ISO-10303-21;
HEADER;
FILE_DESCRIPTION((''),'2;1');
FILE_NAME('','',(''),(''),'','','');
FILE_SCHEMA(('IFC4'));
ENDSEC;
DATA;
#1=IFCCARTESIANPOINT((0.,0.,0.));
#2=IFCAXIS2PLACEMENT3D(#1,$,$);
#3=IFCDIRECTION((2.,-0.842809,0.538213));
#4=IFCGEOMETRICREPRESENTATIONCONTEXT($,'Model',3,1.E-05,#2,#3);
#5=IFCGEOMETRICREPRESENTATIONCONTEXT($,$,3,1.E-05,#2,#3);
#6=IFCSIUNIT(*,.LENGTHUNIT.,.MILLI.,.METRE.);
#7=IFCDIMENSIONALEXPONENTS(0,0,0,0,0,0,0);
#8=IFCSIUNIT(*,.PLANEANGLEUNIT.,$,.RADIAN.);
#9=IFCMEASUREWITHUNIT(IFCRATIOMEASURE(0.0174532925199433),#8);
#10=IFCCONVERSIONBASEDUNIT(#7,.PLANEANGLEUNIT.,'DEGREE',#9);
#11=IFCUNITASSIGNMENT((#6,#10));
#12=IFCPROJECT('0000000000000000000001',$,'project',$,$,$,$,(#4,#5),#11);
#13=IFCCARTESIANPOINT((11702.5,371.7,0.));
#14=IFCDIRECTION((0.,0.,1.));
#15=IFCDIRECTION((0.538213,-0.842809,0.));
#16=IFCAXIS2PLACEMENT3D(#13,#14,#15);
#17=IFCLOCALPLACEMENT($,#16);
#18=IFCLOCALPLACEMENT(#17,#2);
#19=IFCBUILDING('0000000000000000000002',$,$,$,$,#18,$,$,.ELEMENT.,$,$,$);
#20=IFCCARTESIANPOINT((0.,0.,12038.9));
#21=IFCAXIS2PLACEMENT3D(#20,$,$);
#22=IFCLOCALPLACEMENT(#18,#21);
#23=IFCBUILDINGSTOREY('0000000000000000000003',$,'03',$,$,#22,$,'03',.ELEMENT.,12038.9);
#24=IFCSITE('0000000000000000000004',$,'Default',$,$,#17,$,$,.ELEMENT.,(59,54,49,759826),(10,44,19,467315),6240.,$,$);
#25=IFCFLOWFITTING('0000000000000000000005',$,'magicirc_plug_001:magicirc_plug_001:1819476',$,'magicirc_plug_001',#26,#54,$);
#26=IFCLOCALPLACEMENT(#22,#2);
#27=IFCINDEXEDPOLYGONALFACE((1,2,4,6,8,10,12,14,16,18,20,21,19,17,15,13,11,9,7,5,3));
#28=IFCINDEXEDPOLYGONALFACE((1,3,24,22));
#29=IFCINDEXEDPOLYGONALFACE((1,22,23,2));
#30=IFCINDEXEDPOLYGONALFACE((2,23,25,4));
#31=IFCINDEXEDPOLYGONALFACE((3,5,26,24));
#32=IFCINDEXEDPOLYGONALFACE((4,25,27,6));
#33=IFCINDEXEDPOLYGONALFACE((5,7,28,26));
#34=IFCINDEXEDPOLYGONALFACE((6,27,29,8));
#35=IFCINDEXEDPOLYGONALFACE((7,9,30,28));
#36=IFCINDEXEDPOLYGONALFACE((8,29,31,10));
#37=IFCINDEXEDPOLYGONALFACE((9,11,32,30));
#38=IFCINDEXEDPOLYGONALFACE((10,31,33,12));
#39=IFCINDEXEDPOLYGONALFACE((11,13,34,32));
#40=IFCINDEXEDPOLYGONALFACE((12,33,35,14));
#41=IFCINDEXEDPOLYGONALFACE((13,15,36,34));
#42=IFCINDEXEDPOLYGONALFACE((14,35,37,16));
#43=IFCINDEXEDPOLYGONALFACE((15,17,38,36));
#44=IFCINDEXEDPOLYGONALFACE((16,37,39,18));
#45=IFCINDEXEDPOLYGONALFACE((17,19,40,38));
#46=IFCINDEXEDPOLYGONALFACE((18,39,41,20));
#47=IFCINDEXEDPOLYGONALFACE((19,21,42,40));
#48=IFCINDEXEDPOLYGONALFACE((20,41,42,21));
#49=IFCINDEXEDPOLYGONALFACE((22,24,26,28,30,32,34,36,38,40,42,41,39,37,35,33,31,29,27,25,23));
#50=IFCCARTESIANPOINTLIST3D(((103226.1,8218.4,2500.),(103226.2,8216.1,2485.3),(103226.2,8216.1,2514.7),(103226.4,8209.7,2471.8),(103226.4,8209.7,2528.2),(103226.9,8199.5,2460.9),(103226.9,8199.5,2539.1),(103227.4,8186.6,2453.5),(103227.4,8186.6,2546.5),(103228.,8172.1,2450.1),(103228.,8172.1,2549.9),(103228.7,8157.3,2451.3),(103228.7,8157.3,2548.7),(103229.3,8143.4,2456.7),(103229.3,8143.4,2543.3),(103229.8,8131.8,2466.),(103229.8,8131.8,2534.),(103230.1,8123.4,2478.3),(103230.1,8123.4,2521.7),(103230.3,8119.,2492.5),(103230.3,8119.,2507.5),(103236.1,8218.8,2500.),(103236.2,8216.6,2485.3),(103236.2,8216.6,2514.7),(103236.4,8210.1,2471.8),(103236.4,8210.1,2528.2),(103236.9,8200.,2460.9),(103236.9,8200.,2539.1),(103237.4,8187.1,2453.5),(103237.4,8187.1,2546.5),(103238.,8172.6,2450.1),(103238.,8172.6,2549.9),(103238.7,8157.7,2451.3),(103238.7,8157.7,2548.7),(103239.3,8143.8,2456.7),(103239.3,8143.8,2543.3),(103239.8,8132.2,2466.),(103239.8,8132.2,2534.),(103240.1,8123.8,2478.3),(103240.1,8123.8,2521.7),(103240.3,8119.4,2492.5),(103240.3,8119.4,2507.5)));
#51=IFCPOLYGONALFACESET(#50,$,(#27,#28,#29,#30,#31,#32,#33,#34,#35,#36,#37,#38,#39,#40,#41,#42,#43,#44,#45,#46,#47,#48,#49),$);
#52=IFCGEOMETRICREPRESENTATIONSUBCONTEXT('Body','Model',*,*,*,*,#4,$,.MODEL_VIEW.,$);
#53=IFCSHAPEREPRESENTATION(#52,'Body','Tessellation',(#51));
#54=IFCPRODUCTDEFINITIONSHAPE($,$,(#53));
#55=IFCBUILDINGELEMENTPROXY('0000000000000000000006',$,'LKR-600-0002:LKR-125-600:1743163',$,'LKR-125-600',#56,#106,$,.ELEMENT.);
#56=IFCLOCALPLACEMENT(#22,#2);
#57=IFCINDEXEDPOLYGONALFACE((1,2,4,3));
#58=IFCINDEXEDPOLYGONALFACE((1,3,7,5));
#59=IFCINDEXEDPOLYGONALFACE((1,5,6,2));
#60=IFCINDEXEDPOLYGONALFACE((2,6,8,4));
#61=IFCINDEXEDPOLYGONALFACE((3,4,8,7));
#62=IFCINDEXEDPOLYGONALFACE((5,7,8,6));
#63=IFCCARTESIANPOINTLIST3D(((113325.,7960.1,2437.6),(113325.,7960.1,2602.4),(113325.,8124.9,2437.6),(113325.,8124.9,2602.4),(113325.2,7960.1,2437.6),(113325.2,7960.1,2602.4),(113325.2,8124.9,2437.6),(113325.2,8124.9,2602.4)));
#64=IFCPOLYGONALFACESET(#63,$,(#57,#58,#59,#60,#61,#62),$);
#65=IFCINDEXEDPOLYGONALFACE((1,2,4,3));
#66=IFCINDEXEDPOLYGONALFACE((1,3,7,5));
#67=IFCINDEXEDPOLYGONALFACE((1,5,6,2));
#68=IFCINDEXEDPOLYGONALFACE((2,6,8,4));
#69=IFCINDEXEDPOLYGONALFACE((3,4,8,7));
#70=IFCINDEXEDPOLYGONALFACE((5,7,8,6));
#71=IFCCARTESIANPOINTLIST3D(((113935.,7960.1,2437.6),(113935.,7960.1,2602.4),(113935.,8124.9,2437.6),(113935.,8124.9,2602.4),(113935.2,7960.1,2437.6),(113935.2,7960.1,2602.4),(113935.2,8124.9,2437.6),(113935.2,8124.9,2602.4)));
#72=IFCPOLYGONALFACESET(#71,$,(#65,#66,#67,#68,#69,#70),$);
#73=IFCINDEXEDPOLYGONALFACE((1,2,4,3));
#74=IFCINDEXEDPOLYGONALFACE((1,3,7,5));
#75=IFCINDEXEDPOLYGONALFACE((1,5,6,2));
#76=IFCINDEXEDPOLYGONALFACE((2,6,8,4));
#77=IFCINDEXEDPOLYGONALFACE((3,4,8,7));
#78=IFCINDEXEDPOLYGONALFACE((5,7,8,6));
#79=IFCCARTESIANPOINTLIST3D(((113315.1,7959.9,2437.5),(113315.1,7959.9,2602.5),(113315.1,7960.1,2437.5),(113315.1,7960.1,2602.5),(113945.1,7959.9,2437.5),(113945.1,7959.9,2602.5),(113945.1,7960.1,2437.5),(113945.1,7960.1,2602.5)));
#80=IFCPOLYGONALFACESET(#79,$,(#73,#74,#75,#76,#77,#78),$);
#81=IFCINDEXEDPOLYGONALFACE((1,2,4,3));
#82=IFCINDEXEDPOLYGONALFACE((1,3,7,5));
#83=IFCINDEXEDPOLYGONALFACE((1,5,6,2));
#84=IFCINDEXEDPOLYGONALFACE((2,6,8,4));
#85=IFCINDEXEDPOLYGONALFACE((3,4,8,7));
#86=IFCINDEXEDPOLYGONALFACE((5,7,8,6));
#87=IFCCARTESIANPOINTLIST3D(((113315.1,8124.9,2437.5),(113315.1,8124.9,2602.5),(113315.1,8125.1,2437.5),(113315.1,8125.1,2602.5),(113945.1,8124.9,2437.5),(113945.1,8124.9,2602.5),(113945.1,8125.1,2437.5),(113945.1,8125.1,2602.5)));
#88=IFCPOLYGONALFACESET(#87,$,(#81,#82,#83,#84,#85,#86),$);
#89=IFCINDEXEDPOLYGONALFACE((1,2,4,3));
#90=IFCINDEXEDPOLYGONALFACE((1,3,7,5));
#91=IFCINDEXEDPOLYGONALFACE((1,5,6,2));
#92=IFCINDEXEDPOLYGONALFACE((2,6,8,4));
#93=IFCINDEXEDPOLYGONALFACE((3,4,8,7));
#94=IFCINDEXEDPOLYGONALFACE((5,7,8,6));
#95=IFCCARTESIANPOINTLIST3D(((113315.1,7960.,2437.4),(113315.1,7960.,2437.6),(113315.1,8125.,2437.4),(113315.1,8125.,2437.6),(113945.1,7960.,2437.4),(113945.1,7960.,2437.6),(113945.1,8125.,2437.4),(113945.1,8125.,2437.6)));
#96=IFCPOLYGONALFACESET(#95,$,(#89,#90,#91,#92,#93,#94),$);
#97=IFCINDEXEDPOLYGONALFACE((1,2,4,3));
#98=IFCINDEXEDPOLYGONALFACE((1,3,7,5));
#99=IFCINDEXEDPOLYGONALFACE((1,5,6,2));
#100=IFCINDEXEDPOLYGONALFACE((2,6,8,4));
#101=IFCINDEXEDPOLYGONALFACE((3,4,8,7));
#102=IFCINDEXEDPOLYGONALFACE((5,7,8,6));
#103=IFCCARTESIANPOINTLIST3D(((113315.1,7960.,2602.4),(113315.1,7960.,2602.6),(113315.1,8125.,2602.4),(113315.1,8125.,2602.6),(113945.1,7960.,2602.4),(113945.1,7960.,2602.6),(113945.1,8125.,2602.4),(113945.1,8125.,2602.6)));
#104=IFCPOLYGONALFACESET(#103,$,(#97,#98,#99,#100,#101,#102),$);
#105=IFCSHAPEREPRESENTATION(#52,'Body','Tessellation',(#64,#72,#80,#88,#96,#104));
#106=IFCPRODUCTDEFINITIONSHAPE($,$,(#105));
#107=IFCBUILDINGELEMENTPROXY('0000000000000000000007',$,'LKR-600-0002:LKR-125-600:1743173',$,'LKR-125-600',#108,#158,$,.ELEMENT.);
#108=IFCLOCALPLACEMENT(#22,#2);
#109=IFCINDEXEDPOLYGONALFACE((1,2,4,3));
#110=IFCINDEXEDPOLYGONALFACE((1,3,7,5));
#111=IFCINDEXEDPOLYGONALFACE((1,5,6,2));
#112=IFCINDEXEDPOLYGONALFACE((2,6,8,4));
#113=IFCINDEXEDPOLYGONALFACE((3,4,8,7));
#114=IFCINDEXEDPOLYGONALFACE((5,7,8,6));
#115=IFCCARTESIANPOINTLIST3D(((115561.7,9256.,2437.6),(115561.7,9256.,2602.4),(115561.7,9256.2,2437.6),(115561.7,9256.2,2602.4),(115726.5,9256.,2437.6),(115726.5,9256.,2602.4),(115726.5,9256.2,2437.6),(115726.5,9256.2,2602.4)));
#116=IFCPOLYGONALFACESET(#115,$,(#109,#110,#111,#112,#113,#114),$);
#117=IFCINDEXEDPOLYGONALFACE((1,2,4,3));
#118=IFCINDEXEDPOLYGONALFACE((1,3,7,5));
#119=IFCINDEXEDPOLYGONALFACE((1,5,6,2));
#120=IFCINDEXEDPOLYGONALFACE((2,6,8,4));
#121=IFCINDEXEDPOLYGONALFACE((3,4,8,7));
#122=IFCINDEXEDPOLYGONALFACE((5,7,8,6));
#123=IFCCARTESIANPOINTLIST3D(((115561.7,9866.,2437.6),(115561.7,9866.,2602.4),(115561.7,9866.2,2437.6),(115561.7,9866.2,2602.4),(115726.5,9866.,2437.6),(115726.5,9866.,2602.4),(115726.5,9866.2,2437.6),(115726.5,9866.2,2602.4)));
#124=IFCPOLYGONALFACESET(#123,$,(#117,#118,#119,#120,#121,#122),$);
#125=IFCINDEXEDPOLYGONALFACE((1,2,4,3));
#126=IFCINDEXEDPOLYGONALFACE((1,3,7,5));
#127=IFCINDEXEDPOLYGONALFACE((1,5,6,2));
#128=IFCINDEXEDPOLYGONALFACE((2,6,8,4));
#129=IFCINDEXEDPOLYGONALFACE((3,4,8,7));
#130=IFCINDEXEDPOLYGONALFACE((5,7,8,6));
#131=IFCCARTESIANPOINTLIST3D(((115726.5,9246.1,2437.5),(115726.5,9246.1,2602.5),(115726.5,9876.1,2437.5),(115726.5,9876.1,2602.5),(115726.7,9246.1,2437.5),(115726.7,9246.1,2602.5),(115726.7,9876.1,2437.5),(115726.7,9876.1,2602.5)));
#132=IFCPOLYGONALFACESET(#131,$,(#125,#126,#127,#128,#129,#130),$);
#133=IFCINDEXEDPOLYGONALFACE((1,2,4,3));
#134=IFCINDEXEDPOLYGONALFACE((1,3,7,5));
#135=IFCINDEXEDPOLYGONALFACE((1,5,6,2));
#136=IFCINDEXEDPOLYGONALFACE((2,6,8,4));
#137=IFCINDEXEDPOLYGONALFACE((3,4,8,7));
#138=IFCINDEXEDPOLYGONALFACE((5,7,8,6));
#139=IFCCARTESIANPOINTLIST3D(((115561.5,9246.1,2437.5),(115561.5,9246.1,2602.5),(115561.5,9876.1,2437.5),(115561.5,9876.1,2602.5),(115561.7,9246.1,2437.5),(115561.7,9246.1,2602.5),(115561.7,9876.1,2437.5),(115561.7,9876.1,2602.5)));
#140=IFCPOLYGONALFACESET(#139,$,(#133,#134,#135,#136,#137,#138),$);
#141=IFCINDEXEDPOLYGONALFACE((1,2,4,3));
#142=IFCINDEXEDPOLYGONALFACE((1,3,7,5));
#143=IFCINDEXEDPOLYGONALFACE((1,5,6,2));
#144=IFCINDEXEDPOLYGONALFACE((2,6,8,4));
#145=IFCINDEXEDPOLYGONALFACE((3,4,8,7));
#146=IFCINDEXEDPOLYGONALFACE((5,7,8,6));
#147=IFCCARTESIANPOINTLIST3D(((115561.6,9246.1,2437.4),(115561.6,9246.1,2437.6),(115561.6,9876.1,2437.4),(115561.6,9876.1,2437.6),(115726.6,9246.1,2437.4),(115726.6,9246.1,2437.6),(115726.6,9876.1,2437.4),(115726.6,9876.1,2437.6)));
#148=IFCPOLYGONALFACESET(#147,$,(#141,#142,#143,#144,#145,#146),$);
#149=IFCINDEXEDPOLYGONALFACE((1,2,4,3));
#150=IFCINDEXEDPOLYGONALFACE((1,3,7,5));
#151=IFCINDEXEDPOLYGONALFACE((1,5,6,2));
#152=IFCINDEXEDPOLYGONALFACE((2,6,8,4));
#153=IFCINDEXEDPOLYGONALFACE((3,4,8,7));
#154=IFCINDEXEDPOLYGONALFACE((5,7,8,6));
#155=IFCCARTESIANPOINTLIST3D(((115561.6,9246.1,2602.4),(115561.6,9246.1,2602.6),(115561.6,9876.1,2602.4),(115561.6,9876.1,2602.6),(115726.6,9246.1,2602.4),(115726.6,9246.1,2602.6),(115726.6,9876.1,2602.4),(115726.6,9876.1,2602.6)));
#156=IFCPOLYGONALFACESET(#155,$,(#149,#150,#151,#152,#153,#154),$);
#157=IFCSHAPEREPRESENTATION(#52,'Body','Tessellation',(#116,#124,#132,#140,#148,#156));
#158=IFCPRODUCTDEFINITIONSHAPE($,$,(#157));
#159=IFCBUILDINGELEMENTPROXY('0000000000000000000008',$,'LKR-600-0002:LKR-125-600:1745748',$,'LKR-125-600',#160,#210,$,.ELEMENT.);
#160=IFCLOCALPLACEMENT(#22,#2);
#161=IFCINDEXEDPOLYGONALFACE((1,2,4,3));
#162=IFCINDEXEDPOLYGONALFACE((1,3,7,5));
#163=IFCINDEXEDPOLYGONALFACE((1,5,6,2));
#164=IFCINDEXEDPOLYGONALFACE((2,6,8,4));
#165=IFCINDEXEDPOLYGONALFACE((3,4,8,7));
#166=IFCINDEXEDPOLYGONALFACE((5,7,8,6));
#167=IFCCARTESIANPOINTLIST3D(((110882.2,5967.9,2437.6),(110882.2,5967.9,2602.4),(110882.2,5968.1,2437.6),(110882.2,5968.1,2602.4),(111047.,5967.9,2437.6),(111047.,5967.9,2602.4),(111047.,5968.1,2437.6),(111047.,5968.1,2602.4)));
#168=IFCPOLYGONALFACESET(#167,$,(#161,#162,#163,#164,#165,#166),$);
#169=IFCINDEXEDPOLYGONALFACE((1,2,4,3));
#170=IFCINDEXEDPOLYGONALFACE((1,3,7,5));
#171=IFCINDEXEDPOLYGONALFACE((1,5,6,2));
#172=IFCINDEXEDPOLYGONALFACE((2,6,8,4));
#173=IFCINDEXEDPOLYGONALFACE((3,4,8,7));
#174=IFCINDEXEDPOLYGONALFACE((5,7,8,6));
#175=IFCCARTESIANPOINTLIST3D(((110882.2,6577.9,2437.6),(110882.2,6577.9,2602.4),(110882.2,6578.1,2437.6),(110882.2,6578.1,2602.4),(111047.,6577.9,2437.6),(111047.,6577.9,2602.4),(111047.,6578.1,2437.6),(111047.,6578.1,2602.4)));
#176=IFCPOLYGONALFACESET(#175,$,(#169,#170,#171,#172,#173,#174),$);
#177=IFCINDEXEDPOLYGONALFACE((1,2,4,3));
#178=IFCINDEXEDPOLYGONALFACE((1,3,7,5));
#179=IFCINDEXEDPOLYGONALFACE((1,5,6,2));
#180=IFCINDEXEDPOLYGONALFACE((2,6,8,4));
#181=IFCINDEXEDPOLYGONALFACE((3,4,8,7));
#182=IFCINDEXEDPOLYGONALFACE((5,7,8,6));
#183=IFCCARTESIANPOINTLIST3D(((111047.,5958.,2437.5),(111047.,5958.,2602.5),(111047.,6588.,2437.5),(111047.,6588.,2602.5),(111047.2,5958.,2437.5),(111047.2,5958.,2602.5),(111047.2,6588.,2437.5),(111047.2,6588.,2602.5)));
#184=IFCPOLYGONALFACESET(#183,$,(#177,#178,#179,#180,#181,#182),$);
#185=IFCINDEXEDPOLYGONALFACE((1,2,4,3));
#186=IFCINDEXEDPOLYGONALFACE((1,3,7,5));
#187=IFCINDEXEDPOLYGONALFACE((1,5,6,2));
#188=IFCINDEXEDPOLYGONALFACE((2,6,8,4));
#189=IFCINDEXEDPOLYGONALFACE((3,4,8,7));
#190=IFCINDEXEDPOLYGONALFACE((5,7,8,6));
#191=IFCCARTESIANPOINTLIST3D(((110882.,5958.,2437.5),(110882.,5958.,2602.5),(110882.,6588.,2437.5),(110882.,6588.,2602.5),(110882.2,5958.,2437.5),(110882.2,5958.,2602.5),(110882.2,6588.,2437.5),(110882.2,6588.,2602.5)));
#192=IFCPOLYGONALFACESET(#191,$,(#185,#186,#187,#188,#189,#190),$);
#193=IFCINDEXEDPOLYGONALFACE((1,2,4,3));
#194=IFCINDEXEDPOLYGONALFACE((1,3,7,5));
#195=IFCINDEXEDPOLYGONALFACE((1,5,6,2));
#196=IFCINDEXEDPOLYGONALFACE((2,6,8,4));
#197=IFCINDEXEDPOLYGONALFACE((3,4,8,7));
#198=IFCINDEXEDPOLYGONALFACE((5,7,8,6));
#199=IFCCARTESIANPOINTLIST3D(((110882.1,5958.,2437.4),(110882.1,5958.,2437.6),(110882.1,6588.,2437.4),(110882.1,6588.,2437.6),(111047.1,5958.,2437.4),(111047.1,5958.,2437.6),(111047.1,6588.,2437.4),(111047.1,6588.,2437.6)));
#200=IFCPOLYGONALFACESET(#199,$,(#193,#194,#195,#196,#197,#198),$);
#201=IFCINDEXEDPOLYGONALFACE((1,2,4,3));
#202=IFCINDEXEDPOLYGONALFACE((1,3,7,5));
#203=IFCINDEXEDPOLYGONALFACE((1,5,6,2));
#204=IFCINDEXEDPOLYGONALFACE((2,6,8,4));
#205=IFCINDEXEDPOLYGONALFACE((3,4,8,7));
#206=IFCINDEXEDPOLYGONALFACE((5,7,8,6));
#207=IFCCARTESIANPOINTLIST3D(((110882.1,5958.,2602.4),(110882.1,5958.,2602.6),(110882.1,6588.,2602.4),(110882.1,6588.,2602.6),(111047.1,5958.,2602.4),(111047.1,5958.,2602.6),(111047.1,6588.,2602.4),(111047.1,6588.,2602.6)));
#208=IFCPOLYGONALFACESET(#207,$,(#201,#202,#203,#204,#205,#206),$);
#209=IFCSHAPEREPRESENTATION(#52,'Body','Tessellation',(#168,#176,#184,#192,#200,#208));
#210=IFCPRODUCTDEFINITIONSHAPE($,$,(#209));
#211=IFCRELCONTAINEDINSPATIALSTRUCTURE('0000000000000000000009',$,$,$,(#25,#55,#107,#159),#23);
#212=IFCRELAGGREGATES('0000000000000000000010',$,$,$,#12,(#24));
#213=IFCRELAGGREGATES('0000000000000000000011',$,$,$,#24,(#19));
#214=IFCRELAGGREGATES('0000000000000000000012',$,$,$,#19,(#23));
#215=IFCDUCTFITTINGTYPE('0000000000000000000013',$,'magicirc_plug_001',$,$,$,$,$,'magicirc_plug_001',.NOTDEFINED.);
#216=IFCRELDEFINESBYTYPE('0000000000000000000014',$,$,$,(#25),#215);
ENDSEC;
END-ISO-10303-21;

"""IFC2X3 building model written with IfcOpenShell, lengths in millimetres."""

from ifc_helpers import new_model, entity, si_unit, converted_unit, direction, frame, frame_2d, origin, place, context, subcontext, project, spatial, rectangle, circle, extrude, source, transform, mapped, type_object, type_shapes, element, save


model = new_model("IFC2X3")

# Units and contexts
model_context = context("Model", 3, precision=1e-05, world=origin(), true_north=direction((2.0, -0.842809, 0.538213)))
context_of_model = context(None, 3, precision=1e-05, world=origin(), true_north=direction((2.0, -0.842809, 0.538213)))
body_context = subcontext(model_context, "Body", "Model", "MODEL_VIEW")
ifc_project = project(units=[si_unit("LENGTHUNIT", "METRE", prefix="MILLI"), converted_unit("PLANEANGLEUNIT", "DEGREE", entity("IfcRatioMeasure", 0.0174532925199433), si_unit("PLANEANGLEUNIT", "RADIAN"), dimensions=[0, 0, 0, 0, 0, 0, 0])], contexts=[model_context, context_of_model])

# Site, building, storey
site_placement = place(None, frame((11702.5, 371.7, 0.0), z_axis=(0.0, 0.0, 1.0), x_axis=(0.538213, -0.842809, 0.0)))
site = spatial("IfcSite", under=ifc_project, at=site_placement, Name="Default", CompositionType="ELEMENT", RefLatitude=(59, 54, 49, 759826), RefLongitude=(10, 44, 19, 467315), RefElevation=6240.0)
building_placement = place(site_placement, origin())
building = spatial("IfcBuilding", under=site, at=building_placement, CompositionType="ELEMENT")
storey_placement = place(building_placement, frame((0.0, 0.0, 12038.9)))
storey = spatial("IfcBuildingStorey", under=building, at=storey_placement, Name="03", LongName="03", CompositionType="ELEMENT", Elevation=12038.9)

# Flow fitting
duct_fitting_type_1 = type_object("IfcDuctFittingType", Name="magicirc_plug_001", ElementType="magicirc_plug_001", PredefinedType="NOTDEFINED")
shared_shape_1 = source(origin(), body_context, "Body", "SweptSolid", [
    extrude(circle(Radius=50.0, at=frame_2d((0.0, 0.0), x_axis=(1.0, 0.0))), frame((0.0, 0.0, 0.0), z_axis=(1.0, 0.0, 0.0), x_axis=(0.0, 1.0, 0.0)), (0.0, 0.0, 1.0), 10.0),
])
type_shapes(duct_fitting_type_1, [shared_shape_1])
for number, where, z_axis, x_axis, name in (
    (1, (103228.2, 8168.4, 2500.0), (0.0, 0.0, 1.0), (0.999095, 0.042537, 0.0), "magicirc_plug_001:magicirc_plug_001:1819476"),
):
    element("IfcFlowFitting", number, at=place(storey_placement, frame(where, z_axis=z_axis, x_axis=x_axis)), inside=storey, type_object=duct_fitting_type_1, Name=name, ObjectType="magicirc_plug_001", context=body_context, shape_type="MappedRepresentation", body=[
        mapped(shared_shape_1, transform((0.0, 0.0, 0.0), scale=1.0)),
    ])

# Building element proxies
shared_shape_2 = source(origin(), body_context, "Body", "SweptSolid", [
    extrude(rectangle(XDim=0.2, YDim=164.8, at=frame_2d((0.0, 0.0), x_axis=(1.0, 0.0))), frame((305.0, 0.0, -82.4)), (0.0, 0.0, 1.0), 164.8),
    extrude(rectangle(XDim=0.2, YDim=164.8, at=frame_2d((0.0, 0.0), x_axis=(1.0, 0.0))), frame((-305.0, 0.0, -82.4)), (0.0, 0.0, 1.0), 164.8),
    extrude(rectangle(XDim=0.2, YDim=630.0, at=frame_2d((0.0, 0.0), x_axis=(1.0, 0.0))), frame((0.0, 82.5, -82.5), z_axis=(0.0, 0.0, 1.0), x_axis=(0.0, 1.0, 0.0)), (0.0, 0.0, 1.0), 165.0),
    extrude(rectangle(XDim=0.2, YDim=630.0, at=frame_2d((0.0, 0.0), x_axis=(1.0, 0.0))), frame((0.0, -82.5, -82.5), z_axis=(0.0, 0.0, 1.0), x_axis=(0.0, 1.0, 0.0)), (0.0, 0.0, 1.0), 165.0),
    extrude(rectangle(XDim=165.0, YDim=630.0, at=frame_2d((0.0, 0.0), x_axis=(1.0, 0.0))), frame((0.0, 0.0, -82.6), z_axis=(0.0, 0.0, 1.0), x_axis=(0.0, -1.0, 0.0)), (0.0, 0.0, 1.0), 0.2),
    extrude(rectangle(XDim=165.0, YDim=630.0, at=frame_2d((0.0, 0.0), x_axis=(1.0, 0.0))), frame((0.0, 0.0, 82.4), z_axis=(0.0, 0.0, 1.0), x_axis=(0.0, -1.0, 0.0)), (0.0, 0.0, 1.0), 0.2),
])
for number, where, z_axis, x_axis, name in (
    (2, (113630.1, 8042.5, 2520.0), (0.0, 0.0, 1.0), (-1.0, 0.0, 0.0), "LKR-600-0002:LKR-125-600:1743163"),
    (3, (115644.1, 9561.1, 2520.0), (0.0, 0.0, 1.0), (-0.000003, -1.0, 0.0), "LKR-600-0002:LKR-125-600:1743173"),
    (4, (110964.6, 6273.0, 2520.0), (0.0, 0.0, 1.0), (0.0, -1.0, 0.0), "LKR-600-0002:LKR-125-600:1745748"),
):
    element("IfcBuildingElementProxy", number, at=place(storey_placement, frame(where, z_axis=z_axis, x_axis=x_axis)), inside=storey, Name=name, ObjectType="LKR-125-600", CompositionType="ELEMENT", context=body_context, shape_type="MappedRepresentation", body=[
        mapped(shared_shape_2, transform((0.0, 0.0, 0.0), scale=1.0)),
    ])

save(model, "model.ifc")
